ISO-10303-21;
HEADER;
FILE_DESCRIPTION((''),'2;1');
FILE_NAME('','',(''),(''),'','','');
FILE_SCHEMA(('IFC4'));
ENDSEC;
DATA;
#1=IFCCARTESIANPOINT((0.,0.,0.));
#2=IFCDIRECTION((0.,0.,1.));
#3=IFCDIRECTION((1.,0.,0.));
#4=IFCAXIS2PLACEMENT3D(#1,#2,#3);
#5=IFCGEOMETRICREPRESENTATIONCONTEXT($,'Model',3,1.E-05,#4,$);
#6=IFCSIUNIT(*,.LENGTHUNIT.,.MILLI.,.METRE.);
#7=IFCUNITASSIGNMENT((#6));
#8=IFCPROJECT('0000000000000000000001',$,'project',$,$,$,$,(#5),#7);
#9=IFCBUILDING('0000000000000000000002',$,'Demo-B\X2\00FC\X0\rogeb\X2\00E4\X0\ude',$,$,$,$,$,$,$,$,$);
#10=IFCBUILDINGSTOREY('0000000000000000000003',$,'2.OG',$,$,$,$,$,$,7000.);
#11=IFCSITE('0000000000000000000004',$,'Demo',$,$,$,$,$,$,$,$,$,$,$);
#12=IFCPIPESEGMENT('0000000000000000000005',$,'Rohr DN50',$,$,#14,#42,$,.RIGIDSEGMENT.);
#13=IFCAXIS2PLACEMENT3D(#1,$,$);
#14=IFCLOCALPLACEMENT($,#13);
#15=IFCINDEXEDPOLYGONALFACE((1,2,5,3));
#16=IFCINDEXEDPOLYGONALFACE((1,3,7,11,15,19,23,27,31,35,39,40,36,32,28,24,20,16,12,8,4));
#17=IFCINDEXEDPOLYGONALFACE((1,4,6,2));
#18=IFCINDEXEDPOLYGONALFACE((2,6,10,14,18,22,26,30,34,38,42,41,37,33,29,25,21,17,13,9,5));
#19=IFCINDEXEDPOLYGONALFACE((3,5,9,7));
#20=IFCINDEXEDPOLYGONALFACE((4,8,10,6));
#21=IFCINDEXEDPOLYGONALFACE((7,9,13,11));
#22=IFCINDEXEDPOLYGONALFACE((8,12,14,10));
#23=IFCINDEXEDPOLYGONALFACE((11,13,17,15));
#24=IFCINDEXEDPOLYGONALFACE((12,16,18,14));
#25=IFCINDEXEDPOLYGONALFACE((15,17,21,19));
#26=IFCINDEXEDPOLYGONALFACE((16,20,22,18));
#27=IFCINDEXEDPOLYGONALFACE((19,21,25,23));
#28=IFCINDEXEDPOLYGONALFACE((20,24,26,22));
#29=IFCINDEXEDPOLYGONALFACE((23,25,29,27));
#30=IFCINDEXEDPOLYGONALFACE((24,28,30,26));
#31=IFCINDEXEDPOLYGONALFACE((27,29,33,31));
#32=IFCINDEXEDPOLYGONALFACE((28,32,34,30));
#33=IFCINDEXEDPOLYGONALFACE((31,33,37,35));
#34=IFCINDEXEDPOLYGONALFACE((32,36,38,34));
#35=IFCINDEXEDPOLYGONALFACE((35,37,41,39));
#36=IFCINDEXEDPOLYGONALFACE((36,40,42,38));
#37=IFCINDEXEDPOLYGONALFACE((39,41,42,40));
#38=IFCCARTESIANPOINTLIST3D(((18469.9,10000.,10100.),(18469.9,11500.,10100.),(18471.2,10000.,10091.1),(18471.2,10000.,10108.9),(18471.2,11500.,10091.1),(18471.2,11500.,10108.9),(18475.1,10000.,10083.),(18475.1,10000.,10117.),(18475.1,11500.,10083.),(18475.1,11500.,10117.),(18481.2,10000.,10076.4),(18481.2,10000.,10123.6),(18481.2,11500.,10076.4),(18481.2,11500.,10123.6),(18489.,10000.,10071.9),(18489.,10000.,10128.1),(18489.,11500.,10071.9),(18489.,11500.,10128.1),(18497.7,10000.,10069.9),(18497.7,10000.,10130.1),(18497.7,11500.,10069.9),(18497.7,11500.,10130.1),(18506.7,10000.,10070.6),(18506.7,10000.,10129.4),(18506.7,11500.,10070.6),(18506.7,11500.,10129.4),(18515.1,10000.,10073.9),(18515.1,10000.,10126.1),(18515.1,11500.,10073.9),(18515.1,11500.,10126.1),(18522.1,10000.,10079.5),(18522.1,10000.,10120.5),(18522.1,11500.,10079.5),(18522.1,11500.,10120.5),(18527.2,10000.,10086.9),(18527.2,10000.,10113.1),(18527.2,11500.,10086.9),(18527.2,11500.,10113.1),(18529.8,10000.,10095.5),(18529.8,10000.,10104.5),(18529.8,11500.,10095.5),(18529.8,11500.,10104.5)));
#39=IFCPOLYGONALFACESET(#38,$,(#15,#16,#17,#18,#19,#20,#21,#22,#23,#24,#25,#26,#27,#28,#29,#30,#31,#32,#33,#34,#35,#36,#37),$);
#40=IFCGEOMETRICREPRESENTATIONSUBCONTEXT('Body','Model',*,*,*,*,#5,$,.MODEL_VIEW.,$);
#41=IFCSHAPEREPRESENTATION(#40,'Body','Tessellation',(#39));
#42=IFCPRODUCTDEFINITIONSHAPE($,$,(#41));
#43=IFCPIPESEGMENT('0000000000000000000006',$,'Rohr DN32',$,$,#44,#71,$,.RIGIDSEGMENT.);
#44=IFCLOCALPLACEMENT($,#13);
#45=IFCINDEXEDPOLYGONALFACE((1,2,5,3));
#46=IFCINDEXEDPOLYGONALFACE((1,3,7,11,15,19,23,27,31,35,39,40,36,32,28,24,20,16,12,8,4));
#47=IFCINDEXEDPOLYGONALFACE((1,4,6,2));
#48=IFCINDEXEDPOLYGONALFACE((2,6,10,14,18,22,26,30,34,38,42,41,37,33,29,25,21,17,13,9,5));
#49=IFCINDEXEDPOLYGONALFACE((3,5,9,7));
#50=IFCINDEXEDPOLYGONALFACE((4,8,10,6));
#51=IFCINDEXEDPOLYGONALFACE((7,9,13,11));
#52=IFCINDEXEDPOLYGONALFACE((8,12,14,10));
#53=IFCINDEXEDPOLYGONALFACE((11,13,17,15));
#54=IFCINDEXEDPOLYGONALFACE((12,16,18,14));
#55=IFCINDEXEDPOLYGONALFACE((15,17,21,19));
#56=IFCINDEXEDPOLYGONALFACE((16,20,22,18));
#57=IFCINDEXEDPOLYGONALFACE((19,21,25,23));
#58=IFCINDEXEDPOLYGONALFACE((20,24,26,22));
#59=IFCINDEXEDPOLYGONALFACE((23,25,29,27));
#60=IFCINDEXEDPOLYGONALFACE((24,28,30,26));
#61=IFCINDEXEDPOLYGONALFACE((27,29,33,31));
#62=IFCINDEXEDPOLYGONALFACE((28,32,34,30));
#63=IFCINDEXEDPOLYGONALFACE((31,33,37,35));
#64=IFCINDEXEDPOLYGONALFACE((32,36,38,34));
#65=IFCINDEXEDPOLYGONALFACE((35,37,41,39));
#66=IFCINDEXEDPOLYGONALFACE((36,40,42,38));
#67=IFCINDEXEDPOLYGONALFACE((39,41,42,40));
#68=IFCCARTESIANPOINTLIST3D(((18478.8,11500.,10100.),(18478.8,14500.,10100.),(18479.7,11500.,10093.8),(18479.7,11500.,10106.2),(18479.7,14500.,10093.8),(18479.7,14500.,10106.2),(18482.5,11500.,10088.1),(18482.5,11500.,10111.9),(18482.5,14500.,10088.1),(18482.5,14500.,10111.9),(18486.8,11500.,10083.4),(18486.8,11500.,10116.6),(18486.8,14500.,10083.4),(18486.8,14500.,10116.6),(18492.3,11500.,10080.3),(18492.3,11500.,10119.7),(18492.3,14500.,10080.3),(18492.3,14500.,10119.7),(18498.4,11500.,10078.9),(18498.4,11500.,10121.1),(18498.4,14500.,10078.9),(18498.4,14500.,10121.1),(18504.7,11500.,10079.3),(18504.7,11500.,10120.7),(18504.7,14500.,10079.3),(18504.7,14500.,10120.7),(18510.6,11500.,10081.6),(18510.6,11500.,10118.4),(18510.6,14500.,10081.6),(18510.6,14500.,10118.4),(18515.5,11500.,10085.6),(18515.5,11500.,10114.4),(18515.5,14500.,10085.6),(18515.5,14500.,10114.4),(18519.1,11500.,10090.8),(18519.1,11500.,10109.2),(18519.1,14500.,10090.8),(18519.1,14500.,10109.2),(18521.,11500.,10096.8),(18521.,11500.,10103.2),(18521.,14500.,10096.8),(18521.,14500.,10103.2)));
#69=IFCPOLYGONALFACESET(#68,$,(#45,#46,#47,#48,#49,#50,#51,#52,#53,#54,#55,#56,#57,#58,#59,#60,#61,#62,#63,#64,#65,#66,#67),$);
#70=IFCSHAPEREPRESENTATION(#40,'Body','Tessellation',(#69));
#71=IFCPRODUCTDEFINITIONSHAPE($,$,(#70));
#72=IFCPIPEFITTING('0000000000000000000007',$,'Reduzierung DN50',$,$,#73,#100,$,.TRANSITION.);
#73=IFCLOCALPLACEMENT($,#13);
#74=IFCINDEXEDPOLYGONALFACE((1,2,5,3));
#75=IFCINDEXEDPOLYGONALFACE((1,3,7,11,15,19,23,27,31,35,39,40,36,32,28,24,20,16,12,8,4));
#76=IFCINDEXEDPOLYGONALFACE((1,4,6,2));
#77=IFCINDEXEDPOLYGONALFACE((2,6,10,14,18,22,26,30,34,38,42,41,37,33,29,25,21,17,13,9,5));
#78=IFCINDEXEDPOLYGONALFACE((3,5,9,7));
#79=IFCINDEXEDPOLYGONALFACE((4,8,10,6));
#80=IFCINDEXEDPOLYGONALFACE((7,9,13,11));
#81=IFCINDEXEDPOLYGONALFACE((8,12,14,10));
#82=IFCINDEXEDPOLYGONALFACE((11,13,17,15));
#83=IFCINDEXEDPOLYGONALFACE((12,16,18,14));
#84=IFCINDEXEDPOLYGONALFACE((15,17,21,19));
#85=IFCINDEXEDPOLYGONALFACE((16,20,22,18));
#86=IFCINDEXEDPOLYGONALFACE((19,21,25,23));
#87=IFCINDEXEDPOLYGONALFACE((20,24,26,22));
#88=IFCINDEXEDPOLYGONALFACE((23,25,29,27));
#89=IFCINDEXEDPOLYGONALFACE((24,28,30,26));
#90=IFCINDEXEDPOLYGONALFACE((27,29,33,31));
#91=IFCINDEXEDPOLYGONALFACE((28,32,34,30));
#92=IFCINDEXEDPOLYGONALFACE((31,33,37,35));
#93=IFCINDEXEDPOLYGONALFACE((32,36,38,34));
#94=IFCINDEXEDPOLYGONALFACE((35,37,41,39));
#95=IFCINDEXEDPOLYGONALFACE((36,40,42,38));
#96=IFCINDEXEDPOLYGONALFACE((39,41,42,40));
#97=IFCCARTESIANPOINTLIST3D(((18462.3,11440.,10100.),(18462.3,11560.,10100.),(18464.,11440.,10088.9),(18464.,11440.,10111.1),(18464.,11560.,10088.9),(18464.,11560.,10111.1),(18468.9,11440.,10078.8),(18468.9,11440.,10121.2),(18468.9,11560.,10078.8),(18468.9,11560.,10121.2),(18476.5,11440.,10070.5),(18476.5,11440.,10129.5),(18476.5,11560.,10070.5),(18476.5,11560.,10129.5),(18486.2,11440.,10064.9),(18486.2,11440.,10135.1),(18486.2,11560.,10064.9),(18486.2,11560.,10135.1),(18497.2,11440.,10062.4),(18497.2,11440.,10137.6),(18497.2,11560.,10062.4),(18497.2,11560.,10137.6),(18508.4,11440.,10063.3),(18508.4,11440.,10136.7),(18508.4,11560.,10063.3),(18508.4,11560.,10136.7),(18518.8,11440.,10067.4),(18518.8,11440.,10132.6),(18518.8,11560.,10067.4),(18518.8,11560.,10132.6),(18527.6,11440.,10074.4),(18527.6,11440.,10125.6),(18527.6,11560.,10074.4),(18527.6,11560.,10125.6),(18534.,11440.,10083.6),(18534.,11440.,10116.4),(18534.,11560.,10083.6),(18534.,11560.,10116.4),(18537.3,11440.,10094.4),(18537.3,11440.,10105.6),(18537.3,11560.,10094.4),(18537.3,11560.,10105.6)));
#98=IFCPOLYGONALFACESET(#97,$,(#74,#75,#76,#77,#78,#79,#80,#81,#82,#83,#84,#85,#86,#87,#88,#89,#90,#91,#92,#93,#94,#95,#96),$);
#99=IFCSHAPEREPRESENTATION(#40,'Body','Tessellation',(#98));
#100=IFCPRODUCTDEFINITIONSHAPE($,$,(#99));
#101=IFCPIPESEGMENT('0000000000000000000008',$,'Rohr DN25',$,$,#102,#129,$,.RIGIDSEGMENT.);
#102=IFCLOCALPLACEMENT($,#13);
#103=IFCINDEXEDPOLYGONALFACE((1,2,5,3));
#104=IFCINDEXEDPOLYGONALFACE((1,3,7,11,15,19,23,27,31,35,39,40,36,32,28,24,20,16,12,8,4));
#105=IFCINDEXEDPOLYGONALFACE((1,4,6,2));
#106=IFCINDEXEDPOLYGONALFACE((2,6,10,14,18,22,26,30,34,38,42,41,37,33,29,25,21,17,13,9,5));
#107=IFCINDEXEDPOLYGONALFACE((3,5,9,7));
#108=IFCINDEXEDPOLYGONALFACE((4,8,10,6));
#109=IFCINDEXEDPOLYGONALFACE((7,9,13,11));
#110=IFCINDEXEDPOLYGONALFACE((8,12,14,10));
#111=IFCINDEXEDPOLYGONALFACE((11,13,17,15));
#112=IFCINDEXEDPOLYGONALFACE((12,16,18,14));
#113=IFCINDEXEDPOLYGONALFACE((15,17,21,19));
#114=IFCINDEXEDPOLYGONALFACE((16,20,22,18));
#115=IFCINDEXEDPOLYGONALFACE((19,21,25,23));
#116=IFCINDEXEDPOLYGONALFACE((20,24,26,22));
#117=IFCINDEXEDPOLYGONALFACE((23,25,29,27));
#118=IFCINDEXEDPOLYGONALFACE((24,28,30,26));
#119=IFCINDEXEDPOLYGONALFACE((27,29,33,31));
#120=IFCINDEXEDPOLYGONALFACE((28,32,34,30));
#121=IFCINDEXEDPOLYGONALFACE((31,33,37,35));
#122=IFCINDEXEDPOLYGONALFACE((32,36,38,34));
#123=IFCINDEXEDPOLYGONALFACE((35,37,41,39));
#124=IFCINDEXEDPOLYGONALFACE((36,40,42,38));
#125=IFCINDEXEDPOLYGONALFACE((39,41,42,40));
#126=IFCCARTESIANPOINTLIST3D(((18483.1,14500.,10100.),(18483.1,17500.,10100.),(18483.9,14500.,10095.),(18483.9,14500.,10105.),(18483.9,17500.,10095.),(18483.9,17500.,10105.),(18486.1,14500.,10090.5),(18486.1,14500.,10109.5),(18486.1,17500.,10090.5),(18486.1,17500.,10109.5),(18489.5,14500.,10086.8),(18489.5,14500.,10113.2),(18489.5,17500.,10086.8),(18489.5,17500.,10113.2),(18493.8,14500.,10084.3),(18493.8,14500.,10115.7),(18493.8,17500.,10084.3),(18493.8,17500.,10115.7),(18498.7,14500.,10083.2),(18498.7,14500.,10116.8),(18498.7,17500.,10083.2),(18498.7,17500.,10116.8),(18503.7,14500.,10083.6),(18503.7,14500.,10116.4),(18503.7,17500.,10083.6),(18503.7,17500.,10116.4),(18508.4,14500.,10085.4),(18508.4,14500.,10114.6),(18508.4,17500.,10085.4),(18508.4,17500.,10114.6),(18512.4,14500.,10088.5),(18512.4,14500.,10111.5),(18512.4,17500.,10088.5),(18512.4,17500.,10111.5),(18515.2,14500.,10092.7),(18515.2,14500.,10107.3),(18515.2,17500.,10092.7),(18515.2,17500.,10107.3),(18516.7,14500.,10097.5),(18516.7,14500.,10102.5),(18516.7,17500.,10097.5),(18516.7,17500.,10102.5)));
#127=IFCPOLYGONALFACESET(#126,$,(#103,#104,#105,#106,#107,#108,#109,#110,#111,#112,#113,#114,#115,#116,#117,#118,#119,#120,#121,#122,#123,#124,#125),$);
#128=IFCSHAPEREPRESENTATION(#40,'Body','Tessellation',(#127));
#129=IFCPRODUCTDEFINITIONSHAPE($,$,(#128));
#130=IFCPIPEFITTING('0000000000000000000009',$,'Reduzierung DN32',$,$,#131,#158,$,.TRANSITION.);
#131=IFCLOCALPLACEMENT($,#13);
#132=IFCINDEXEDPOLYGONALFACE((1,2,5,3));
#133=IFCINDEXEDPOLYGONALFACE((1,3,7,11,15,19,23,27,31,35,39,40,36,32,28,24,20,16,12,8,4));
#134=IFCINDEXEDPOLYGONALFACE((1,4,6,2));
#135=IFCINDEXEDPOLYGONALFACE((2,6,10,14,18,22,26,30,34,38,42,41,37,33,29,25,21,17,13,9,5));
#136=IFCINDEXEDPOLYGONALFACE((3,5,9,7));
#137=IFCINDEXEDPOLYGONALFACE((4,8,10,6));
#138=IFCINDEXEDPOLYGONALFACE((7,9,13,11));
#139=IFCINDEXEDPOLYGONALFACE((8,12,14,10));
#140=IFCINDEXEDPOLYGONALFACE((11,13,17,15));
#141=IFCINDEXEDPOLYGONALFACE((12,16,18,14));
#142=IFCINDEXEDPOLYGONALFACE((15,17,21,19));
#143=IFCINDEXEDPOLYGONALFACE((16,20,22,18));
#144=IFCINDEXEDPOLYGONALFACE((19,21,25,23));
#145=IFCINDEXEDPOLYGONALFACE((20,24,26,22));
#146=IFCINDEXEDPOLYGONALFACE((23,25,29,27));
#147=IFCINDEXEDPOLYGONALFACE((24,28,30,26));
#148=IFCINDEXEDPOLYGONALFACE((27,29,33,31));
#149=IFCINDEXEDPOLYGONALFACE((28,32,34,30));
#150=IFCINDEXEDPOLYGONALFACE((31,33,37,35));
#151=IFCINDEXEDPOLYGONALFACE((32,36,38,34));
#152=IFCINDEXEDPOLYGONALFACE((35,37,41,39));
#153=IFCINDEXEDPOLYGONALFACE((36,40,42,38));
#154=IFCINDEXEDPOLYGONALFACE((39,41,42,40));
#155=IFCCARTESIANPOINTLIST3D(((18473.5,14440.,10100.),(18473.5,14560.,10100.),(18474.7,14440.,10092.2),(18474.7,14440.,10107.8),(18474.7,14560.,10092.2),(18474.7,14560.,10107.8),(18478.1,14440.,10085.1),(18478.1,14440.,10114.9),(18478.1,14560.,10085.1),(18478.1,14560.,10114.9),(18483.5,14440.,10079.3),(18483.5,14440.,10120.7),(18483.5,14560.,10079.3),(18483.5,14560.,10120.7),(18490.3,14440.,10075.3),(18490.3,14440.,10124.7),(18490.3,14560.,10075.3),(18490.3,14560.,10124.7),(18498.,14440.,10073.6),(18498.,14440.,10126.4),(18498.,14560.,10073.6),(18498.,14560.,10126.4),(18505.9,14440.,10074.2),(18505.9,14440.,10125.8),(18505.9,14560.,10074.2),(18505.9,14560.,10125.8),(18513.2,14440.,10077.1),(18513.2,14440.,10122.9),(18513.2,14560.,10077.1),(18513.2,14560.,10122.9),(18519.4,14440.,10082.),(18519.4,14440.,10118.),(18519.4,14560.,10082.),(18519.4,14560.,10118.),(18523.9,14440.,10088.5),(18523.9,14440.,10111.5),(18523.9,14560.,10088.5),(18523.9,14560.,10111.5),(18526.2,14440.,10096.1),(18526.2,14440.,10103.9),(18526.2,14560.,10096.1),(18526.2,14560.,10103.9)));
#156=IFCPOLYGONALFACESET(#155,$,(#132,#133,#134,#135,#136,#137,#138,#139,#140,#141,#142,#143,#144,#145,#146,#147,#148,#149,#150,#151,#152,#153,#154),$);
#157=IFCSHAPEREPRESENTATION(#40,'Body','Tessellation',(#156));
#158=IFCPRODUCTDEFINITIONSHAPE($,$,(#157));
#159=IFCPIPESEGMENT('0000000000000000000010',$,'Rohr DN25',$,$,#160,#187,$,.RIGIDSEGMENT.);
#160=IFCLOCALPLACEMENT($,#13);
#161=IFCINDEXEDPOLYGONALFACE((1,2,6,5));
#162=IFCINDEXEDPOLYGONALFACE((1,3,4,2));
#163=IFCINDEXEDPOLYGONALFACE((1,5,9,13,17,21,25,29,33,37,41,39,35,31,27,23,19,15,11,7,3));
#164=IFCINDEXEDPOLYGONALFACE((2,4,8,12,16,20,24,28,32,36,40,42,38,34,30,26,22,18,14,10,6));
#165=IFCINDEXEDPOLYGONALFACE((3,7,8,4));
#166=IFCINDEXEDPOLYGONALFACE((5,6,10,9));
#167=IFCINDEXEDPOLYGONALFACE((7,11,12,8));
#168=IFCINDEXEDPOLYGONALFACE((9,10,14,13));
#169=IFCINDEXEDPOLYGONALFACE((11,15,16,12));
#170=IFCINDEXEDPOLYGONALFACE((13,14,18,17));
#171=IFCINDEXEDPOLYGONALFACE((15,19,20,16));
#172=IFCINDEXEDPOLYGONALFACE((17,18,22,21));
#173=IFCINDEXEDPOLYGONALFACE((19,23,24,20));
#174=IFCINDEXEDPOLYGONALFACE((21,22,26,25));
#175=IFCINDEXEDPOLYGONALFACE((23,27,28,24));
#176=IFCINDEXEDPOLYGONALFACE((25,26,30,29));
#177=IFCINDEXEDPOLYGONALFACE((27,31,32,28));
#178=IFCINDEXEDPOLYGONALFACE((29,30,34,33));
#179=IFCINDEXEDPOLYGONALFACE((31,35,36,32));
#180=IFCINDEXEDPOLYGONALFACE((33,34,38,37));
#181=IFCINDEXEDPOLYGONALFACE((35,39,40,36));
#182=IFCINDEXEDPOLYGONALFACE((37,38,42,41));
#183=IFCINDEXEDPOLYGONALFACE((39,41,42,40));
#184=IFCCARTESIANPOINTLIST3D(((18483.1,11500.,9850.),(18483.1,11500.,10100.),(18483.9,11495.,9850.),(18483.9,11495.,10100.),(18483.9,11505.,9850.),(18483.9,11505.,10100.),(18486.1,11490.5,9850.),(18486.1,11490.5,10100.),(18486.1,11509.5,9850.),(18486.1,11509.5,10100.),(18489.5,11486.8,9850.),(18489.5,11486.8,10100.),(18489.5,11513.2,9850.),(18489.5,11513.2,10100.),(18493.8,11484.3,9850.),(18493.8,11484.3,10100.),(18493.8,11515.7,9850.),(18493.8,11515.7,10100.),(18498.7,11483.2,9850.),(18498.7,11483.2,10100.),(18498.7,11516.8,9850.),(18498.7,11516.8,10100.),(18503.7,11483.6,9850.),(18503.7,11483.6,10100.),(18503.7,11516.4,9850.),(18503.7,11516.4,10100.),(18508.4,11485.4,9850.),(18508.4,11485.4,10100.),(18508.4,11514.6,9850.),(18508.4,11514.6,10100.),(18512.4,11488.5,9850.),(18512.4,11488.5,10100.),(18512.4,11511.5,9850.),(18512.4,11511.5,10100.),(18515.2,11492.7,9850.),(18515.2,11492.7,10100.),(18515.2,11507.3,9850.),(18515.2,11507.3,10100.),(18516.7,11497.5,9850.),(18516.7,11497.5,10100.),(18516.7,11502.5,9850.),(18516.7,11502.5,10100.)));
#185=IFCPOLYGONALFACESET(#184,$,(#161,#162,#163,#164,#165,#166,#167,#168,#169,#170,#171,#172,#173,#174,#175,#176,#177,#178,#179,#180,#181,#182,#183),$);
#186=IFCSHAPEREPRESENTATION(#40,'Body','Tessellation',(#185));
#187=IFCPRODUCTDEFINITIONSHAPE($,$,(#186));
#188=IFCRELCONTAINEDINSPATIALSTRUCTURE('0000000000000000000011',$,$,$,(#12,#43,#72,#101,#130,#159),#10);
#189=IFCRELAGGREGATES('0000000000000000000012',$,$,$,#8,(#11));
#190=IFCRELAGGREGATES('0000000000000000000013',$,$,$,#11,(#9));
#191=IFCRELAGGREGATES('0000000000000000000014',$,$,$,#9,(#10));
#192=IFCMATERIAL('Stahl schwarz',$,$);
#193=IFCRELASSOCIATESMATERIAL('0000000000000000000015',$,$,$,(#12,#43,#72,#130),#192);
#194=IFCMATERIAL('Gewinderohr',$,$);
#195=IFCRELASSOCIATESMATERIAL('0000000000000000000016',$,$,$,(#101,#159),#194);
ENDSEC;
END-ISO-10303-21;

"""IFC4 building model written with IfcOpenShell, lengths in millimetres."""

from ifc_helpers import new_model, si_unit, frame, origin_with_axes, place, context, subcontext, project, spatial, circle, extrude, material, element, save


model = new_model("IFC4")

# Units and contexts
model_context = context("Model", 3, precision=1e-05, world=origin_with_axes())
body_context = subcontext(model_context, "Body", "Model", "MODEL_VIEW")
ifc_project = project(units=[si_unit("LENGTHUNIT", "METRE", prefix="MILLI")], contexts=[model_context])

# Site, building, storey
site = spatial("IfcSite", under=ifc_project, Name="Demo")
building = spatial("IfcBuilding", under=site, Name="Demo-Bürogebäude")
storey = spatial("IfcBuildingStorey", under=building, Name="2.OG", Elevation=7000.0)

# Shared definitions
ifc_material_1 = material(Name="Gewinderohr")

# Shared definitions
ifc_material_2 = material(Name="Stahl schwarz")

# Pipe segments
pipe_segment_1_placement = place(None, frame((18500.0, 10000.0, 10100.0), z_axis=(0.0, 1.0, 0.0), x_axis=(-1.0, 0.0, 0.0)))
element("IfcPipeSegment", 1, at=pipe_segment_1_placement, inside=storey, material=ifc_material_2, Name="Rohr DN50", PredefinedType="RIGIDSEGMENT", context=body_context, shape_type="SweptSolid", body=[
    extrude(circle(Radius=30.1), origin_with_axes(), (0.0, 0.0, 1.0), 1500.0),
])
pipe_segment_2_placement = place(None, frame((18500.0, 11500.0, 10100.0), z_axis=(0.0, 1.0, 0.0), x_axis=(-1.0, 0.0, 0.0)))
element("IfcPipeSegment", 2, at=pipe_segment_2_placement, inside=storey, material=ifc_material_2, Name="Rohr DN32", PredefinedType="RIGIDSEGMENT", context=body_context, shape_type="SweptSolid", body=[
    extrude(circle(Radius=21.2), origin_with_axes(), (0.0, 0.0, 1.0), 3000.0),
])

# Pipe fitting
pipe_fitting_1_placement = place(None, frame((18500.0, 11440.0, 10100.0), z_axis=(0.0, 1.0, 0.0), x_axis=(-1.0, 0.0, 0.0)))
element("IfcPipeFitting", 3, at=pipe_fitting_1_placement, inside=storey, material=ifc_material_2, Name="Reduzierung DN50", PredefinedType="TRANSITION", context=body_context, shape_type="SweptSolid", body=[
    extrude(circle(Radius=37.7), origin_with_axes(), (0.0, 0.0, 1.0), 120.0),
])

# Pipe segment
pipe_segment_3_placement = place(None, frame((18500.0, 14500.0, 10100.0), z_axis=(0.0, 1.0, 0.0), x_axis=(-1.0, 0.0, 0.0)))
element("IfcPipeSegment", 4, at=pipe_segment_3_placement, inside=storey, material=ifc_material_1, Name="Rohr DN25", PredefinedType="RIGIDSEGMENT", context=body_context, shape_type="SweptSolid", body=[
    extrude(circle(Radius=16.9), origin_with_axes(), (0.0, 0.0, 1.0), 3000.0),
])

# Pipe fitting
pipe_fitting_2_placement = place(None, frame((18500.0, 14440.0, 10100.0), z_axis=(0.0, 1.0, 0.0), x_axis=(-1.0, 0.0, 0.0)))
element("IfcPipeFitting", 5, at=pipe_fitting_2_placement, inside=storey, material=ifc_material_2, Name="Reduzierung DN32", PredefinedType="TRANSITION", context=body_context, shape_type="SweptSolid", body=[
    extrude(circle(Radius=26.5), origin_with_axes(), (0.0, 0.0, 1.0), 120.0),
])

# Pipe segment
pipe_segment_4_placement = place(None, frame((18500.0, 11500.0, 10100.0), z_axis=(0.0, 0.0, -1.0), x_axis=(-1.0, 0.0, 0.0)))
element("IfcPipeSegment", 6, at=pipe_segment_4_placement, inside=storey, material=ifc_material_1, Name="Rohr DN25", PredefinedType="RIGIDSEGMENT", context=body_context, shape_type="SweptSolid", body=[
    extrude(circle(Radius=16.9), origin_with_axes(), (0.0, 0.0, 1.0), 250.0),
])

save(model, "model.ifc")
